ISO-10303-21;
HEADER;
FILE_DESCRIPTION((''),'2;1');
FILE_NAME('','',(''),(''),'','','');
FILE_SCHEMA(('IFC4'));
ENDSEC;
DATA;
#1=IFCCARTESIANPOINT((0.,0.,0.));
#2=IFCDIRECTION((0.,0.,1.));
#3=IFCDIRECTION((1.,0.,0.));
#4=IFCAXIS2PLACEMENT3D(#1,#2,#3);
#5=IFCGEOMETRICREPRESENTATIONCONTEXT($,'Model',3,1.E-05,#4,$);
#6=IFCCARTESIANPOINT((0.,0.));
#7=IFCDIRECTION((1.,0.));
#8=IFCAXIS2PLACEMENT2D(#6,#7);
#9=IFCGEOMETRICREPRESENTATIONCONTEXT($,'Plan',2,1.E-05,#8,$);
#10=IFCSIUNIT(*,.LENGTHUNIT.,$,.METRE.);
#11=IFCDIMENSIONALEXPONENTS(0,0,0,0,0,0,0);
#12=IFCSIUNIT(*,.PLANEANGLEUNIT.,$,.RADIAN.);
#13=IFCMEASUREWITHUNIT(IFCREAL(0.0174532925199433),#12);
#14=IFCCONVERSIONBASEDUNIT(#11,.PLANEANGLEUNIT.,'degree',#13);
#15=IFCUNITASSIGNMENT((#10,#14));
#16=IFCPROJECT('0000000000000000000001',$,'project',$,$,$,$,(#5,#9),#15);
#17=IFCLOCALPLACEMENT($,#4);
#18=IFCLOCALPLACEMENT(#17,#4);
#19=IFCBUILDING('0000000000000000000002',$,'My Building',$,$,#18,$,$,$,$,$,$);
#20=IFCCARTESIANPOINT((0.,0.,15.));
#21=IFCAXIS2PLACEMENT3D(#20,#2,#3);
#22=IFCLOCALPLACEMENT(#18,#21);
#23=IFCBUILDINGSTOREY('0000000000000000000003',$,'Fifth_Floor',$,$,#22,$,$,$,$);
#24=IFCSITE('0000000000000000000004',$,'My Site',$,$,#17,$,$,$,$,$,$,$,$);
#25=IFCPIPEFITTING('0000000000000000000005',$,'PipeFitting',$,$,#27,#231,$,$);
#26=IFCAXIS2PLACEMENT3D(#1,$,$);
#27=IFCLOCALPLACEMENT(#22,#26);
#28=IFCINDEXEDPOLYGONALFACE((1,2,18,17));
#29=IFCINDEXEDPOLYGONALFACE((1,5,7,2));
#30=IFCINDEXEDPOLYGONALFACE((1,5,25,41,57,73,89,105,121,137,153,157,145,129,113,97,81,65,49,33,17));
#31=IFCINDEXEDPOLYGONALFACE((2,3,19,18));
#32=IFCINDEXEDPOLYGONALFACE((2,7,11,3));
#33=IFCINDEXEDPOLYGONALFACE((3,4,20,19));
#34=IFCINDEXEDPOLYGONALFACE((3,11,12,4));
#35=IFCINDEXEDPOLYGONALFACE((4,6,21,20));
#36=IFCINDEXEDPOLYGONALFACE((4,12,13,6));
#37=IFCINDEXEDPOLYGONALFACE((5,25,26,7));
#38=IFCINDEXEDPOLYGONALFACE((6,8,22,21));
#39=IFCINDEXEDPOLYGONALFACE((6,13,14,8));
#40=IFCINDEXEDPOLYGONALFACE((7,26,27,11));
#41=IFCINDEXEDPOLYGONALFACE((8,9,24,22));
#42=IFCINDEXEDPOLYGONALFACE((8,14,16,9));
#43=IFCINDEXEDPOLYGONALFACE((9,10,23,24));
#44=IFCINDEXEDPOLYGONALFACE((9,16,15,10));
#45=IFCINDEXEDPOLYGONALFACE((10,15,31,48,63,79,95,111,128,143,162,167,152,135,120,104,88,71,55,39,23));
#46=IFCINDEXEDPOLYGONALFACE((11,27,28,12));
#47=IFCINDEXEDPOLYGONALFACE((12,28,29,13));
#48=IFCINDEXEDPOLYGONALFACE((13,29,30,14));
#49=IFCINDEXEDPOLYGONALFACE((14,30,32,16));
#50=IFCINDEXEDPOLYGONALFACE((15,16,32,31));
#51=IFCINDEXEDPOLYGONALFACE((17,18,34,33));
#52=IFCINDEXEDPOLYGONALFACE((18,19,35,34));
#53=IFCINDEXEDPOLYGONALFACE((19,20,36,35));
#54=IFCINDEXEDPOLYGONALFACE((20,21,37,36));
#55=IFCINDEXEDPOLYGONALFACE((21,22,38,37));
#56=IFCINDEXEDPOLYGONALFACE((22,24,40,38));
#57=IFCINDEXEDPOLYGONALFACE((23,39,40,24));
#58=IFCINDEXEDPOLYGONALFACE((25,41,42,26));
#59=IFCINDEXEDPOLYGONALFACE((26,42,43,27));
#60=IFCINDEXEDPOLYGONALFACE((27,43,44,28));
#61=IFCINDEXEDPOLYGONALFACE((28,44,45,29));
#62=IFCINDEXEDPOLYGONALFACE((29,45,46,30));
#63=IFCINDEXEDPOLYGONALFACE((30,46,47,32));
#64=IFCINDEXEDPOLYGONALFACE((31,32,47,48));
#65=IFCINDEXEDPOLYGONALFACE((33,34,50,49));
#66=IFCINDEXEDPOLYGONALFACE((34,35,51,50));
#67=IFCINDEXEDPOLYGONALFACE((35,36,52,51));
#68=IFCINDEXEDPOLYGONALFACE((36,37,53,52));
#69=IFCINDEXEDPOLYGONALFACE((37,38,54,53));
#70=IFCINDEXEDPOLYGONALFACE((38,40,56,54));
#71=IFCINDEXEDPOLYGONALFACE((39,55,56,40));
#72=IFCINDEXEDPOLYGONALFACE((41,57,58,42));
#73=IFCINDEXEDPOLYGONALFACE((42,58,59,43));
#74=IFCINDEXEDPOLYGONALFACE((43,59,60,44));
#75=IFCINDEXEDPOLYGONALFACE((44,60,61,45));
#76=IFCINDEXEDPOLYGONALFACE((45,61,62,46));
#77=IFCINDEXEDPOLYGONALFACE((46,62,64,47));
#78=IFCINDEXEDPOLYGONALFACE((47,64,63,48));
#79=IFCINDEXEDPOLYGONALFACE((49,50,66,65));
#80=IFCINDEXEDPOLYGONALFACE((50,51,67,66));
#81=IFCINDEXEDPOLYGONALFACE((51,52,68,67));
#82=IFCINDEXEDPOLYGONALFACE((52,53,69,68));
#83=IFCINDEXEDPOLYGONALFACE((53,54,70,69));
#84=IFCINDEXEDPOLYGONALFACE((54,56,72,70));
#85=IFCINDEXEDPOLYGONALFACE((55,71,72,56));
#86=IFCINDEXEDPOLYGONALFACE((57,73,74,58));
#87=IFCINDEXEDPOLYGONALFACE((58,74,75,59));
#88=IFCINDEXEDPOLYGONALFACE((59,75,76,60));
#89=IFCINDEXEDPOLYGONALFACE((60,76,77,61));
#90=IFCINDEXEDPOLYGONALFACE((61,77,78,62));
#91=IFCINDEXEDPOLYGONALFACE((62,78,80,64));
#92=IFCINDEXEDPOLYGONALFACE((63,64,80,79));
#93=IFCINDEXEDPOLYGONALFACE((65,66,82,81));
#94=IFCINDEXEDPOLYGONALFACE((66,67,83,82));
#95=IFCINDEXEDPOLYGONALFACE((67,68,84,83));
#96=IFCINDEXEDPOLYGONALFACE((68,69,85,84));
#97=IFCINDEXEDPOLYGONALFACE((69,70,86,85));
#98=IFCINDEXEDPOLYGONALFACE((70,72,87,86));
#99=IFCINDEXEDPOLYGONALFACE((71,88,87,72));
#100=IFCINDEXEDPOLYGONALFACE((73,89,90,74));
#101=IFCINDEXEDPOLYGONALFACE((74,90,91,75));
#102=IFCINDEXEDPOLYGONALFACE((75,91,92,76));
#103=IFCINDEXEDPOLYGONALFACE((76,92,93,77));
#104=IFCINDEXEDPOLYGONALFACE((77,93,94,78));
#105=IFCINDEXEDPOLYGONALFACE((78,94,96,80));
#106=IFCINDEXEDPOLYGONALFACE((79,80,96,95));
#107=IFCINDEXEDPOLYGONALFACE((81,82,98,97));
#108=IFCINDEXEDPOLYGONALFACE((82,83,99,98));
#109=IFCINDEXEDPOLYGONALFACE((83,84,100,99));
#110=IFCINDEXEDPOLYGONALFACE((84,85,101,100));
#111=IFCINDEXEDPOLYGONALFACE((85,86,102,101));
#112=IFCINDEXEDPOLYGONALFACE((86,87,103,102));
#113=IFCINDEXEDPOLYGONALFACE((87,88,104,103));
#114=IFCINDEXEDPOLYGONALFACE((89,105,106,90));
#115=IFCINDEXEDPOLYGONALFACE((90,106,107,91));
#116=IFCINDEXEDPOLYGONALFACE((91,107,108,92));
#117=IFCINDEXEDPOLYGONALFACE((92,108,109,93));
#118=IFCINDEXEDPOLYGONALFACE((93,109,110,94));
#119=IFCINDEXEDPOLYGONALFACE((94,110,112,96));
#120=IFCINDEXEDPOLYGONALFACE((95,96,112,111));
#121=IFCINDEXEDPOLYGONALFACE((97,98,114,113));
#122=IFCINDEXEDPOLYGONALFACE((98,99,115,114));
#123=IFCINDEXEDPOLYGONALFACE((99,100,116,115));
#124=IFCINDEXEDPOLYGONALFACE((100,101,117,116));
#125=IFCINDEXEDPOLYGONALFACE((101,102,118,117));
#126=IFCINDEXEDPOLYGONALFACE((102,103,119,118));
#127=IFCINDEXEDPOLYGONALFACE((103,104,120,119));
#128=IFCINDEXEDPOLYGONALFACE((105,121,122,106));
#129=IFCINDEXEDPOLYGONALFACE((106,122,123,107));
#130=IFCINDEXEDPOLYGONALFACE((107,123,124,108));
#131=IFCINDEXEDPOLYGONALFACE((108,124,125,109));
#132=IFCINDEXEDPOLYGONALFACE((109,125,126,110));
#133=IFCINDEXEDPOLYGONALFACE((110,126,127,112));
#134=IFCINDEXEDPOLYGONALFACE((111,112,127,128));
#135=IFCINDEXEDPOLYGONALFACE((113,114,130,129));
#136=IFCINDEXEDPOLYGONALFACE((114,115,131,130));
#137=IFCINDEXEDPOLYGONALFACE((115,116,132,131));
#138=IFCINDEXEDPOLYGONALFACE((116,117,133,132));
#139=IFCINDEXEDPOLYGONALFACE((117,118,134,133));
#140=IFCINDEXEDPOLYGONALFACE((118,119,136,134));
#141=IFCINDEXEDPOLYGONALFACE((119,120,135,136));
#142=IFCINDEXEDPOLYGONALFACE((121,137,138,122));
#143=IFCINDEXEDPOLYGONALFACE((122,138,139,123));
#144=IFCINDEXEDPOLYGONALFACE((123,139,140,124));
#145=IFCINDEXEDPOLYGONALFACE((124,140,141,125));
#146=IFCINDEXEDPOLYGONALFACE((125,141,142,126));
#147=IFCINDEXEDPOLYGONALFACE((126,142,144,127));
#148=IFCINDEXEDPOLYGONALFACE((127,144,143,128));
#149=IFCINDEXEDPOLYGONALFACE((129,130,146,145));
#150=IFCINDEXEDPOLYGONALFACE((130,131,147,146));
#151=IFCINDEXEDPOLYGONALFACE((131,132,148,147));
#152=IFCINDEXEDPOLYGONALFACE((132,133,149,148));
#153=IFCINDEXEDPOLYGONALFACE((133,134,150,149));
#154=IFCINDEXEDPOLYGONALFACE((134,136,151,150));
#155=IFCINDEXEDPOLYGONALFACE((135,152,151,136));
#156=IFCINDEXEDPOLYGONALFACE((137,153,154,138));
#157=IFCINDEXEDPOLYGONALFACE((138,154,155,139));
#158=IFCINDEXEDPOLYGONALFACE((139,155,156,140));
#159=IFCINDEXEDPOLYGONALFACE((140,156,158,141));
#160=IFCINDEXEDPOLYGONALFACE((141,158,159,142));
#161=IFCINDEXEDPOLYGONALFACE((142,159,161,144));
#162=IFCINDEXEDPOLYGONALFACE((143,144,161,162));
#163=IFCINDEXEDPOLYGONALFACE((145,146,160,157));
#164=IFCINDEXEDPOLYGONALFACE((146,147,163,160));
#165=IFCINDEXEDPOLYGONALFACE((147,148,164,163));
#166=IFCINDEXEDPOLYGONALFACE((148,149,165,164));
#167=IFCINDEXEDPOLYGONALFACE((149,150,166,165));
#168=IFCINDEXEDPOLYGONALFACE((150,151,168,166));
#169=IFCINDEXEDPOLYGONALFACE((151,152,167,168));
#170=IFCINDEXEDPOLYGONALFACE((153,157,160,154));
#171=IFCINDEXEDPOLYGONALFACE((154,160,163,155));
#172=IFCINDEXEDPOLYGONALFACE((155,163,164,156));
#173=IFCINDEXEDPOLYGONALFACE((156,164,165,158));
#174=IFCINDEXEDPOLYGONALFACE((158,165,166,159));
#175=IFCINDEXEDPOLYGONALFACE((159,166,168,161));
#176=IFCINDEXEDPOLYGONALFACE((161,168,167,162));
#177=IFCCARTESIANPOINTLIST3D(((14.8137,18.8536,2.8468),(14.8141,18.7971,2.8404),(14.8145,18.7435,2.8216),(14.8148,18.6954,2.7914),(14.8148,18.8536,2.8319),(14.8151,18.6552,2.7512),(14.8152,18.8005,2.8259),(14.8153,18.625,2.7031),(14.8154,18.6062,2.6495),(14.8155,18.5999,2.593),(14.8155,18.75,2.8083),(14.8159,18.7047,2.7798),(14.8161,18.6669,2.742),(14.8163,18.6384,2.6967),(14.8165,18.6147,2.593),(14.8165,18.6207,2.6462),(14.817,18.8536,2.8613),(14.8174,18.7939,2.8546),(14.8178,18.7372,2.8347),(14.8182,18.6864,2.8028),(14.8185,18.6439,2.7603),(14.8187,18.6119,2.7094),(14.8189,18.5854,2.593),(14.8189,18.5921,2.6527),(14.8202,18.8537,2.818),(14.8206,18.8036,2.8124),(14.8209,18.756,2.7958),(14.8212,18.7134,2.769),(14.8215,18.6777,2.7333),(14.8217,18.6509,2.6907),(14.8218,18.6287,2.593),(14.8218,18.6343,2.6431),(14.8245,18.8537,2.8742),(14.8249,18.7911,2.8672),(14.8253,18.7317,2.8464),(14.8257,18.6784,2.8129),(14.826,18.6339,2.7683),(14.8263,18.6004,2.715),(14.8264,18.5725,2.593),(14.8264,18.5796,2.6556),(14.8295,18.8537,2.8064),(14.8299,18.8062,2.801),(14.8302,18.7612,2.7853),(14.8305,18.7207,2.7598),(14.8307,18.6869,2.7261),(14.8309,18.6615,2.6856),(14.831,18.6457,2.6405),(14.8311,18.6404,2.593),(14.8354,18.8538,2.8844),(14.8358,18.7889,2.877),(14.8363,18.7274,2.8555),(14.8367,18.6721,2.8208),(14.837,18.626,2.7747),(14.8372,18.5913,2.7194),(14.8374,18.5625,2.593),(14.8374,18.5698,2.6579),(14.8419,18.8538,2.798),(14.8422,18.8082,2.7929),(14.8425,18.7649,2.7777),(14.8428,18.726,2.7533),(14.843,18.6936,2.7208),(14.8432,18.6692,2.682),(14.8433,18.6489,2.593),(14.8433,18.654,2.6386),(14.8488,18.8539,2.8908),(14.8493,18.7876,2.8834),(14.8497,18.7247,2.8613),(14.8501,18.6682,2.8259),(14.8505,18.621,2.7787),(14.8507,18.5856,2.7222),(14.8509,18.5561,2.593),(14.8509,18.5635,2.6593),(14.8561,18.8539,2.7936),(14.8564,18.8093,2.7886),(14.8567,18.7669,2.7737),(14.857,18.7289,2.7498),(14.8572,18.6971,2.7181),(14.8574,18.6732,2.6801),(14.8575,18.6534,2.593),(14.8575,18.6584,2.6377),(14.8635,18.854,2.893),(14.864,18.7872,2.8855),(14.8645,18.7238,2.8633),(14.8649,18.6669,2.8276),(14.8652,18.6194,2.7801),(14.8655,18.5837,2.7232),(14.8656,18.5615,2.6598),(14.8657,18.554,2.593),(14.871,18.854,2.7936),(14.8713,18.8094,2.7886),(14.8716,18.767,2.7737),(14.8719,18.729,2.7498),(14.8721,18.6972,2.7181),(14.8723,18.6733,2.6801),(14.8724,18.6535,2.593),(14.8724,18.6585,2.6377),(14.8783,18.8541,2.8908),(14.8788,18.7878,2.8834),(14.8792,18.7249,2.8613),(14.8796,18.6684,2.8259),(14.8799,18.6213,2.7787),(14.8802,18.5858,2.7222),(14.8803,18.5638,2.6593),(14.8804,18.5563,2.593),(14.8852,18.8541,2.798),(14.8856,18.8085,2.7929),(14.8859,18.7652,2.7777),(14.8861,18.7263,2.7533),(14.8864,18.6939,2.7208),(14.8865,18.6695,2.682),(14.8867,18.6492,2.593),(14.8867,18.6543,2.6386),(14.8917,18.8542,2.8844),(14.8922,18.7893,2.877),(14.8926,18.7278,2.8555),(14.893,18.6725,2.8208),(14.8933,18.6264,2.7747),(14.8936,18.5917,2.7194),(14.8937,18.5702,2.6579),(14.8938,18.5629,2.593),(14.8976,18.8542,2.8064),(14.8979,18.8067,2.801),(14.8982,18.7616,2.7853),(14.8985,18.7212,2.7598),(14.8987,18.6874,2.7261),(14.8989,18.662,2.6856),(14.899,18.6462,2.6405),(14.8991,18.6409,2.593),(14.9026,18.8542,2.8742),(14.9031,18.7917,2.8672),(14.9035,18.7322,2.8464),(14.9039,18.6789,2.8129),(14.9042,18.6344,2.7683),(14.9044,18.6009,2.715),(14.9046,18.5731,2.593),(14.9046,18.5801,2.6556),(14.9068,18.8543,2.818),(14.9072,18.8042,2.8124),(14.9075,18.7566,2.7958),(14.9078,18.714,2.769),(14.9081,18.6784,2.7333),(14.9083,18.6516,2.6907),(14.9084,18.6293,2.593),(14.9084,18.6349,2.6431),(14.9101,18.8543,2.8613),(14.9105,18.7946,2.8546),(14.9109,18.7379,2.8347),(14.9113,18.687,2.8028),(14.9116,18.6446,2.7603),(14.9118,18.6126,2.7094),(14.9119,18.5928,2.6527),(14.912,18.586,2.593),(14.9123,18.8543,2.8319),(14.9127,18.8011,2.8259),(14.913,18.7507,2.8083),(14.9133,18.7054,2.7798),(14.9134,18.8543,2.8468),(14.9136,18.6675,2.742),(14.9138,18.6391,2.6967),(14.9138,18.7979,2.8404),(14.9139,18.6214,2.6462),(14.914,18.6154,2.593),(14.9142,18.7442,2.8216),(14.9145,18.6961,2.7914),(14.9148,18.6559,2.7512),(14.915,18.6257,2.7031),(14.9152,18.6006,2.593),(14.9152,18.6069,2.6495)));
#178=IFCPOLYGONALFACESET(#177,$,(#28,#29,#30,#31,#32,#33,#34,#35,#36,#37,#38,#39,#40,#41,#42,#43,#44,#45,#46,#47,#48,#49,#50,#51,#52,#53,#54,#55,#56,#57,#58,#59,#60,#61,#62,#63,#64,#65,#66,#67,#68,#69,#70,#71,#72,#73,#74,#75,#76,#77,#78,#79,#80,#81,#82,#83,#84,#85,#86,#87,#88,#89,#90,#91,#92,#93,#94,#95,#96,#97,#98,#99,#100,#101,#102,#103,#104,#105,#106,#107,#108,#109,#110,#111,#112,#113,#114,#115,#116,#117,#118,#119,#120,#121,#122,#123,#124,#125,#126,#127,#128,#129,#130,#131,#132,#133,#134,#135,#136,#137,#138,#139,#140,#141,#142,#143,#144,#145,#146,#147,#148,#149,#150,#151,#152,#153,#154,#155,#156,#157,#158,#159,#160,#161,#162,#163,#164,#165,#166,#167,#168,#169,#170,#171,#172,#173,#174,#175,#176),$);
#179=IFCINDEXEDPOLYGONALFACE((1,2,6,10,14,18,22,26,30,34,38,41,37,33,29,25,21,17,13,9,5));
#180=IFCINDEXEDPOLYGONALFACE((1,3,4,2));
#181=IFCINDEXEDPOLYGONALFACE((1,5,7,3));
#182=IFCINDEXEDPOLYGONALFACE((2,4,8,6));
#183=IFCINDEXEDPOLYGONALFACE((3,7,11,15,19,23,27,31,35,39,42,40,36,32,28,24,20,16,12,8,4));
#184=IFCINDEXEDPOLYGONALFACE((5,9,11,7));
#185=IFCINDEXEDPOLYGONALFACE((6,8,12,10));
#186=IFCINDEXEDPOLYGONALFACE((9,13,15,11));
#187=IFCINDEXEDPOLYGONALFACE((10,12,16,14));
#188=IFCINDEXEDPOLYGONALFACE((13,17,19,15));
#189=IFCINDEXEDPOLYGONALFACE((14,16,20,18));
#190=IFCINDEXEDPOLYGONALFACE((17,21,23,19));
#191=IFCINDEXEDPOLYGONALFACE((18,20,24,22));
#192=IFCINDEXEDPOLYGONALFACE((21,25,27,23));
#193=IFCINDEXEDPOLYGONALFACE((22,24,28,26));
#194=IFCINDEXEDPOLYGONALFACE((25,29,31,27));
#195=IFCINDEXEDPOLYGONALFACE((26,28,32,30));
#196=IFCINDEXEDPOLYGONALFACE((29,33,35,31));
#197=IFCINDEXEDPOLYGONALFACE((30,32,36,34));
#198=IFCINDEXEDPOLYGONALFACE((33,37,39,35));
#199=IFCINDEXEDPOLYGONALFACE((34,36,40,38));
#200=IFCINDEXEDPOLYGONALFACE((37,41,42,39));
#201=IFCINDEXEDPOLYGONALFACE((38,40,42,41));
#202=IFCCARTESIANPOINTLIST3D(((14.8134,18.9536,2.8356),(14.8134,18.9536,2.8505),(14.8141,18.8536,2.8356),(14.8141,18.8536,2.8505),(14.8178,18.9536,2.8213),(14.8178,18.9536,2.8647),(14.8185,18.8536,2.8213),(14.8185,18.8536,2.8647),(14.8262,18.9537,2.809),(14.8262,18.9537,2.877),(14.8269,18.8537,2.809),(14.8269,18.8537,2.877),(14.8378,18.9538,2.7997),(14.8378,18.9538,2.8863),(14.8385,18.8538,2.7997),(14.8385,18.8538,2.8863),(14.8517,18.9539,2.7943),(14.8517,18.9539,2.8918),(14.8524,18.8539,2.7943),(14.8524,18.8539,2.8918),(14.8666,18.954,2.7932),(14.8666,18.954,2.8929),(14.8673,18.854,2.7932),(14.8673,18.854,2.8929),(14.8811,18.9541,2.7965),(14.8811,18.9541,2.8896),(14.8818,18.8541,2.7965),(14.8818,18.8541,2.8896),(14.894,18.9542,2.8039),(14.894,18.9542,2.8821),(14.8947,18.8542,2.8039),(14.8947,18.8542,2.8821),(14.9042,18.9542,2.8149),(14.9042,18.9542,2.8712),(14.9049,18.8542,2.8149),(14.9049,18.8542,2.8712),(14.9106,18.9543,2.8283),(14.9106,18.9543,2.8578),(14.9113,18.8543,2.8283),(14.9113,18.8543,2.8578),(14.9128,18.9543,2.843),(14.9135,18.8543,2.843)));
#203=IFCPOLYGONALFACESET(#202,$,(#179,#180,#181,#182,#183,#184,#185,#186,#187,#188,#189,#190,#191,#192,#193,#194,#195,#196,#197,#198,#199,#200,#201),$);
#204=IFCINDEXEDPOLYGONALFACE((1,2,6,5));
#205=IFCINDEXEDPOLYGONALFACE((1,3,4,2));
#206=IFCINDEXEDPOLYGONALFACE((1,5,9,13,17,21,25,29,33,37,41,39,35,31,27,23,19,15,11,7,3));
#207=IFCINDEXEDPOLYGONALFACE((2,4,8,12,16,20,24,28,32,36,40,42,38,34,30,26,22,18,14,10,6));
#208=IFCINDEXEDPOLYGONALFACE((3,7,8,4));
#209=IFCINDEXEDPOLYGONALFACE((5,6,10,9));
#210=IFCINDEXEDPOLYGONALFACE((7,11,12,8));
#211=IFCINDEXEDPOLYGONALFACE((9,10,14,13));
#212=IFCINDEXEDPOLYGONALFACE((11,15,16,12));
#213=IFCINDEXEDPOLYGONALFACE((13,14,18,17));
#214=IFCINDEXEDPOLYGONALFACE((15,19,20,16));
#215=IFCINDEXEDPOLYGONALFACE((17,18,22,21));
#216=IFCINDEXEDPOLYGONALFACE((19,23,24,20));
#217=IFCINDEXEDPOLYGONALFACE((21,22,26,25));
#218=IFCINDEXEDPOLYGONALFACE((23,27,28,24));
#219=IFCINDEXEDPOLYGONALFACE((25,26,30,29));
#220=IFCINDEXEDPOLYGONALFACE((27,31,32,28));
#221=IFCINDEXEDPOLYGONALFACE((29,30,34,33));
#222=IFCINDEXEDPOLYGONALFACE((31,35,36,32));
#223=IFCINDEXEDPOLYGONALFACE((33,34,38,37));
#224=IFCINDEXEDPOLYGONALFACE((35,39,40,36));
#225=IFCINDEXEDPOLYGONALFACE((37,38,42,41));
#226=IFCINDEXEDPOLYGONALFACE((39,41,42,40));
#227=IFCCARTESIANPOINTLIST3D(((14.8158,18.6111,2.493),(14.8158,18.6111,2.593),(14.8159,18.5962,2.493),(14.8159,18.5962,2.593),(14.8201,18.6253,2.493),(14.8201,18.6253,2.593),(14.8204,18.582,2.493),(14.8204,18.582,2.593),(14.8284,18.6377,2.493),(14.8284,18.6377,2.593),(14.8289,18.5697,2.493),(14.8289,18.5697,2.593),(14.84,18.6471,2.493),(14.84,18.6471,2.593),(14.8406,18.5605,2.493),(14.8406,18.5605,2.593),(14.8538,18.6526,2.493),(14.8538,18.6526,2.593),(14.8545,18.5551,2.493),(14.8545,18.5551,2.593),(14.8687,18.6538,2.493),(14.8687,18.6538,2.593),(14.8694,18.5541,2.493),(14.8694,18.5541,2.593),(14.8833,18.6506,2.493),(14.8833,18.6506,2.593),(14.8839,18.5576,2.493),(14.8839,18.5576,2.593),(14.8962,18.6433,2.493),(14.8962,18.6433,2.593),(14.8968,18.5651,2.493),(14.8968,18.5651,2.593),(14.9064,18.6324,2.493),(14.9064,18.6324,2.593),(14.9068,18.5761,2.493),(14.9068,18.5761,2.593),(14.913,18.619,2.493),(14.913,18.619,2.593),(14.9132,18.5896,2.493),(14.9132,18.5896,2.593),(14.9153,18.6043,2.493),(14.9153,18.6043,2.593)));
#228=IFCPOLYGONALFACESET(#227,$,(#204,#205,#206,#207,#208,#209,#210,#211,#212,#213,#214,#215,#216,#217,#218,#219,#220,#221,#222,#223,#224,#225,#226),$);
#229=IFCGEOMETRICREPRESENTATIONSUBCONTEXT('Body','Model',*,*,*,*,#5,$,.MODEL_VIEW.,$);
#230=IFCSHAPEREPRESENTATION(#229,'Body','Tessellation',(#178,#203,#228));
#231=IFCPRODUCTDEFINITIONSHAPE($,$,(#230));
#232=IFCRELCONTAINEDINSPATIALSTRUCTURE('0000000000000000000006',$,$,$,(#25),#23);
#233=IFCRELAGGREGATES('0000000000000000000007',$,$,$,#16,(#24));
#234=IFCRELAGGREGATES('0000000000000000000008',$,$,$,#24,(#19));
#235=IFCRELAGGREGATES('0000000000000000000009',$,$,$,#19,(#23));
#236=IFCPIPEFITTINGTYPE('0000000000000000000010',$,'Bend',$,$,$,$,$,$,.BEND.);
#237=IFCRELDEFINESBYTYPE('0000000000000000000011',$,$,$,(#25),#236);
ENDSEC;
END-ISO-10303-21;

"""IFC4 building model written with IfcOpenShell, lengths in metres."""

from ifc_helpers import new_model, entity, si_unit, converted_unit, frame, origin_with_axes, origin_2d_with_axis, place, context, subcontext, project, spatial, circle, extrude, source, transform, mapped, type_object, type_shapes, element, save


model = new_model("IFC4")

# Units and contexts
model_context = context("Model", 3, precision=1e-05, world=origin_with_axes())
plan_context = context("Plan", 2, precision=1e-05, world=origin_2d_with_axis())
body_context_1 = subcontext(model_context, "Body", "Model", "MODEL_VIEW")
ifc_project = project(units=[si_unit("LENGTHUNIT", "METRE"), converted_unit("PLANEANGLEUNIT", "degree", entity("IfcReal", 0.0174532925199433), si_unit("PLANEANGLEUNIT", "RADIAN"), dimensions=[0, 0, 0, 0, 0, 0, 0])], contexts=[model_context, plan_context])

# Site, building, storey
site_placement = place(None, origin_with_axes())
site = spatial("IfcSite", under=ifc_project, at=site_placement, Name="My Site")
building_placement = place(site_placement, origin_with_axes())
building = spatial("IfcBuilding", under=site, at=building_placement, Name="My Building")
storey_placement = place(building_placement, frame((0.0, 0.0, 15.0), z_axis=(0.0, 0.0, 1.0), x_axis=(1.0, 0.0, 0.0)))
storey = spatial("IfcBuildingStorey", under=building, at=storey_placement, Name="Fifth_Floor")

# Pipe fitting
pipe_fitting_type = type_object("IfcPipeFittingType", Name="Bend", PredefinedType="BEND")
shared_shape_1 = source(origin_with_axes(), body_context_1, "Body", "SolidModel", [
    entity("IfcSweptDiskSolid", entity("IfcIndexedPolyCurve", entity("IfcCartesianPointList3D", [[0.0, 0.0, -0.1], [0.0, 0.0732, -0.2768], [0.0, 0.25, -0.35]]), [entity("IfcArcIndex", [1, 2, 3])]), 0.05),
    extrude(circle(Radius=0.05), origin_with_axes(), (0.0, 0.0, -1.0), 0.1),
    extrude(circle(Radius=0.05), frame((0.0, 0.25, -0.35), z_axis=(0.0, 1.0, 0.0), x_axis=(1.0, 0.0, 0.0)), (0.0, 0.0, 1.0), 0.1),
])
type_shapes(pipe_fitting_type, [shared_shape_1])
for number, where, z_axis, x_axis, name in (
    (1, (14.8628, 18.954, 2.843), (-0.007084, 0.999975, 0.0), (0.999975, 0.007084, 0.0), "PipeFitting"),
):
    element("IfcPipeFitting", number, at=place(storey_placement, frame(where, z_axis=z_axis, x_axis=x_axis)), inside=storey, type_object=pipe_fitting_type, Name=name, context=body_context_1, shape_type="MappedRepresentation", body=[
        mapped(shared_shape_1, transform((0.0, 0.0, 0.0), x_axis=(1.0, 0.0, 0.0), y_axis=(0.0, 1.0, 0.0), z_axis=(0.0, 0.0, 1.0), scale=1.0)),
    ])

save(model, "model.ifc")
